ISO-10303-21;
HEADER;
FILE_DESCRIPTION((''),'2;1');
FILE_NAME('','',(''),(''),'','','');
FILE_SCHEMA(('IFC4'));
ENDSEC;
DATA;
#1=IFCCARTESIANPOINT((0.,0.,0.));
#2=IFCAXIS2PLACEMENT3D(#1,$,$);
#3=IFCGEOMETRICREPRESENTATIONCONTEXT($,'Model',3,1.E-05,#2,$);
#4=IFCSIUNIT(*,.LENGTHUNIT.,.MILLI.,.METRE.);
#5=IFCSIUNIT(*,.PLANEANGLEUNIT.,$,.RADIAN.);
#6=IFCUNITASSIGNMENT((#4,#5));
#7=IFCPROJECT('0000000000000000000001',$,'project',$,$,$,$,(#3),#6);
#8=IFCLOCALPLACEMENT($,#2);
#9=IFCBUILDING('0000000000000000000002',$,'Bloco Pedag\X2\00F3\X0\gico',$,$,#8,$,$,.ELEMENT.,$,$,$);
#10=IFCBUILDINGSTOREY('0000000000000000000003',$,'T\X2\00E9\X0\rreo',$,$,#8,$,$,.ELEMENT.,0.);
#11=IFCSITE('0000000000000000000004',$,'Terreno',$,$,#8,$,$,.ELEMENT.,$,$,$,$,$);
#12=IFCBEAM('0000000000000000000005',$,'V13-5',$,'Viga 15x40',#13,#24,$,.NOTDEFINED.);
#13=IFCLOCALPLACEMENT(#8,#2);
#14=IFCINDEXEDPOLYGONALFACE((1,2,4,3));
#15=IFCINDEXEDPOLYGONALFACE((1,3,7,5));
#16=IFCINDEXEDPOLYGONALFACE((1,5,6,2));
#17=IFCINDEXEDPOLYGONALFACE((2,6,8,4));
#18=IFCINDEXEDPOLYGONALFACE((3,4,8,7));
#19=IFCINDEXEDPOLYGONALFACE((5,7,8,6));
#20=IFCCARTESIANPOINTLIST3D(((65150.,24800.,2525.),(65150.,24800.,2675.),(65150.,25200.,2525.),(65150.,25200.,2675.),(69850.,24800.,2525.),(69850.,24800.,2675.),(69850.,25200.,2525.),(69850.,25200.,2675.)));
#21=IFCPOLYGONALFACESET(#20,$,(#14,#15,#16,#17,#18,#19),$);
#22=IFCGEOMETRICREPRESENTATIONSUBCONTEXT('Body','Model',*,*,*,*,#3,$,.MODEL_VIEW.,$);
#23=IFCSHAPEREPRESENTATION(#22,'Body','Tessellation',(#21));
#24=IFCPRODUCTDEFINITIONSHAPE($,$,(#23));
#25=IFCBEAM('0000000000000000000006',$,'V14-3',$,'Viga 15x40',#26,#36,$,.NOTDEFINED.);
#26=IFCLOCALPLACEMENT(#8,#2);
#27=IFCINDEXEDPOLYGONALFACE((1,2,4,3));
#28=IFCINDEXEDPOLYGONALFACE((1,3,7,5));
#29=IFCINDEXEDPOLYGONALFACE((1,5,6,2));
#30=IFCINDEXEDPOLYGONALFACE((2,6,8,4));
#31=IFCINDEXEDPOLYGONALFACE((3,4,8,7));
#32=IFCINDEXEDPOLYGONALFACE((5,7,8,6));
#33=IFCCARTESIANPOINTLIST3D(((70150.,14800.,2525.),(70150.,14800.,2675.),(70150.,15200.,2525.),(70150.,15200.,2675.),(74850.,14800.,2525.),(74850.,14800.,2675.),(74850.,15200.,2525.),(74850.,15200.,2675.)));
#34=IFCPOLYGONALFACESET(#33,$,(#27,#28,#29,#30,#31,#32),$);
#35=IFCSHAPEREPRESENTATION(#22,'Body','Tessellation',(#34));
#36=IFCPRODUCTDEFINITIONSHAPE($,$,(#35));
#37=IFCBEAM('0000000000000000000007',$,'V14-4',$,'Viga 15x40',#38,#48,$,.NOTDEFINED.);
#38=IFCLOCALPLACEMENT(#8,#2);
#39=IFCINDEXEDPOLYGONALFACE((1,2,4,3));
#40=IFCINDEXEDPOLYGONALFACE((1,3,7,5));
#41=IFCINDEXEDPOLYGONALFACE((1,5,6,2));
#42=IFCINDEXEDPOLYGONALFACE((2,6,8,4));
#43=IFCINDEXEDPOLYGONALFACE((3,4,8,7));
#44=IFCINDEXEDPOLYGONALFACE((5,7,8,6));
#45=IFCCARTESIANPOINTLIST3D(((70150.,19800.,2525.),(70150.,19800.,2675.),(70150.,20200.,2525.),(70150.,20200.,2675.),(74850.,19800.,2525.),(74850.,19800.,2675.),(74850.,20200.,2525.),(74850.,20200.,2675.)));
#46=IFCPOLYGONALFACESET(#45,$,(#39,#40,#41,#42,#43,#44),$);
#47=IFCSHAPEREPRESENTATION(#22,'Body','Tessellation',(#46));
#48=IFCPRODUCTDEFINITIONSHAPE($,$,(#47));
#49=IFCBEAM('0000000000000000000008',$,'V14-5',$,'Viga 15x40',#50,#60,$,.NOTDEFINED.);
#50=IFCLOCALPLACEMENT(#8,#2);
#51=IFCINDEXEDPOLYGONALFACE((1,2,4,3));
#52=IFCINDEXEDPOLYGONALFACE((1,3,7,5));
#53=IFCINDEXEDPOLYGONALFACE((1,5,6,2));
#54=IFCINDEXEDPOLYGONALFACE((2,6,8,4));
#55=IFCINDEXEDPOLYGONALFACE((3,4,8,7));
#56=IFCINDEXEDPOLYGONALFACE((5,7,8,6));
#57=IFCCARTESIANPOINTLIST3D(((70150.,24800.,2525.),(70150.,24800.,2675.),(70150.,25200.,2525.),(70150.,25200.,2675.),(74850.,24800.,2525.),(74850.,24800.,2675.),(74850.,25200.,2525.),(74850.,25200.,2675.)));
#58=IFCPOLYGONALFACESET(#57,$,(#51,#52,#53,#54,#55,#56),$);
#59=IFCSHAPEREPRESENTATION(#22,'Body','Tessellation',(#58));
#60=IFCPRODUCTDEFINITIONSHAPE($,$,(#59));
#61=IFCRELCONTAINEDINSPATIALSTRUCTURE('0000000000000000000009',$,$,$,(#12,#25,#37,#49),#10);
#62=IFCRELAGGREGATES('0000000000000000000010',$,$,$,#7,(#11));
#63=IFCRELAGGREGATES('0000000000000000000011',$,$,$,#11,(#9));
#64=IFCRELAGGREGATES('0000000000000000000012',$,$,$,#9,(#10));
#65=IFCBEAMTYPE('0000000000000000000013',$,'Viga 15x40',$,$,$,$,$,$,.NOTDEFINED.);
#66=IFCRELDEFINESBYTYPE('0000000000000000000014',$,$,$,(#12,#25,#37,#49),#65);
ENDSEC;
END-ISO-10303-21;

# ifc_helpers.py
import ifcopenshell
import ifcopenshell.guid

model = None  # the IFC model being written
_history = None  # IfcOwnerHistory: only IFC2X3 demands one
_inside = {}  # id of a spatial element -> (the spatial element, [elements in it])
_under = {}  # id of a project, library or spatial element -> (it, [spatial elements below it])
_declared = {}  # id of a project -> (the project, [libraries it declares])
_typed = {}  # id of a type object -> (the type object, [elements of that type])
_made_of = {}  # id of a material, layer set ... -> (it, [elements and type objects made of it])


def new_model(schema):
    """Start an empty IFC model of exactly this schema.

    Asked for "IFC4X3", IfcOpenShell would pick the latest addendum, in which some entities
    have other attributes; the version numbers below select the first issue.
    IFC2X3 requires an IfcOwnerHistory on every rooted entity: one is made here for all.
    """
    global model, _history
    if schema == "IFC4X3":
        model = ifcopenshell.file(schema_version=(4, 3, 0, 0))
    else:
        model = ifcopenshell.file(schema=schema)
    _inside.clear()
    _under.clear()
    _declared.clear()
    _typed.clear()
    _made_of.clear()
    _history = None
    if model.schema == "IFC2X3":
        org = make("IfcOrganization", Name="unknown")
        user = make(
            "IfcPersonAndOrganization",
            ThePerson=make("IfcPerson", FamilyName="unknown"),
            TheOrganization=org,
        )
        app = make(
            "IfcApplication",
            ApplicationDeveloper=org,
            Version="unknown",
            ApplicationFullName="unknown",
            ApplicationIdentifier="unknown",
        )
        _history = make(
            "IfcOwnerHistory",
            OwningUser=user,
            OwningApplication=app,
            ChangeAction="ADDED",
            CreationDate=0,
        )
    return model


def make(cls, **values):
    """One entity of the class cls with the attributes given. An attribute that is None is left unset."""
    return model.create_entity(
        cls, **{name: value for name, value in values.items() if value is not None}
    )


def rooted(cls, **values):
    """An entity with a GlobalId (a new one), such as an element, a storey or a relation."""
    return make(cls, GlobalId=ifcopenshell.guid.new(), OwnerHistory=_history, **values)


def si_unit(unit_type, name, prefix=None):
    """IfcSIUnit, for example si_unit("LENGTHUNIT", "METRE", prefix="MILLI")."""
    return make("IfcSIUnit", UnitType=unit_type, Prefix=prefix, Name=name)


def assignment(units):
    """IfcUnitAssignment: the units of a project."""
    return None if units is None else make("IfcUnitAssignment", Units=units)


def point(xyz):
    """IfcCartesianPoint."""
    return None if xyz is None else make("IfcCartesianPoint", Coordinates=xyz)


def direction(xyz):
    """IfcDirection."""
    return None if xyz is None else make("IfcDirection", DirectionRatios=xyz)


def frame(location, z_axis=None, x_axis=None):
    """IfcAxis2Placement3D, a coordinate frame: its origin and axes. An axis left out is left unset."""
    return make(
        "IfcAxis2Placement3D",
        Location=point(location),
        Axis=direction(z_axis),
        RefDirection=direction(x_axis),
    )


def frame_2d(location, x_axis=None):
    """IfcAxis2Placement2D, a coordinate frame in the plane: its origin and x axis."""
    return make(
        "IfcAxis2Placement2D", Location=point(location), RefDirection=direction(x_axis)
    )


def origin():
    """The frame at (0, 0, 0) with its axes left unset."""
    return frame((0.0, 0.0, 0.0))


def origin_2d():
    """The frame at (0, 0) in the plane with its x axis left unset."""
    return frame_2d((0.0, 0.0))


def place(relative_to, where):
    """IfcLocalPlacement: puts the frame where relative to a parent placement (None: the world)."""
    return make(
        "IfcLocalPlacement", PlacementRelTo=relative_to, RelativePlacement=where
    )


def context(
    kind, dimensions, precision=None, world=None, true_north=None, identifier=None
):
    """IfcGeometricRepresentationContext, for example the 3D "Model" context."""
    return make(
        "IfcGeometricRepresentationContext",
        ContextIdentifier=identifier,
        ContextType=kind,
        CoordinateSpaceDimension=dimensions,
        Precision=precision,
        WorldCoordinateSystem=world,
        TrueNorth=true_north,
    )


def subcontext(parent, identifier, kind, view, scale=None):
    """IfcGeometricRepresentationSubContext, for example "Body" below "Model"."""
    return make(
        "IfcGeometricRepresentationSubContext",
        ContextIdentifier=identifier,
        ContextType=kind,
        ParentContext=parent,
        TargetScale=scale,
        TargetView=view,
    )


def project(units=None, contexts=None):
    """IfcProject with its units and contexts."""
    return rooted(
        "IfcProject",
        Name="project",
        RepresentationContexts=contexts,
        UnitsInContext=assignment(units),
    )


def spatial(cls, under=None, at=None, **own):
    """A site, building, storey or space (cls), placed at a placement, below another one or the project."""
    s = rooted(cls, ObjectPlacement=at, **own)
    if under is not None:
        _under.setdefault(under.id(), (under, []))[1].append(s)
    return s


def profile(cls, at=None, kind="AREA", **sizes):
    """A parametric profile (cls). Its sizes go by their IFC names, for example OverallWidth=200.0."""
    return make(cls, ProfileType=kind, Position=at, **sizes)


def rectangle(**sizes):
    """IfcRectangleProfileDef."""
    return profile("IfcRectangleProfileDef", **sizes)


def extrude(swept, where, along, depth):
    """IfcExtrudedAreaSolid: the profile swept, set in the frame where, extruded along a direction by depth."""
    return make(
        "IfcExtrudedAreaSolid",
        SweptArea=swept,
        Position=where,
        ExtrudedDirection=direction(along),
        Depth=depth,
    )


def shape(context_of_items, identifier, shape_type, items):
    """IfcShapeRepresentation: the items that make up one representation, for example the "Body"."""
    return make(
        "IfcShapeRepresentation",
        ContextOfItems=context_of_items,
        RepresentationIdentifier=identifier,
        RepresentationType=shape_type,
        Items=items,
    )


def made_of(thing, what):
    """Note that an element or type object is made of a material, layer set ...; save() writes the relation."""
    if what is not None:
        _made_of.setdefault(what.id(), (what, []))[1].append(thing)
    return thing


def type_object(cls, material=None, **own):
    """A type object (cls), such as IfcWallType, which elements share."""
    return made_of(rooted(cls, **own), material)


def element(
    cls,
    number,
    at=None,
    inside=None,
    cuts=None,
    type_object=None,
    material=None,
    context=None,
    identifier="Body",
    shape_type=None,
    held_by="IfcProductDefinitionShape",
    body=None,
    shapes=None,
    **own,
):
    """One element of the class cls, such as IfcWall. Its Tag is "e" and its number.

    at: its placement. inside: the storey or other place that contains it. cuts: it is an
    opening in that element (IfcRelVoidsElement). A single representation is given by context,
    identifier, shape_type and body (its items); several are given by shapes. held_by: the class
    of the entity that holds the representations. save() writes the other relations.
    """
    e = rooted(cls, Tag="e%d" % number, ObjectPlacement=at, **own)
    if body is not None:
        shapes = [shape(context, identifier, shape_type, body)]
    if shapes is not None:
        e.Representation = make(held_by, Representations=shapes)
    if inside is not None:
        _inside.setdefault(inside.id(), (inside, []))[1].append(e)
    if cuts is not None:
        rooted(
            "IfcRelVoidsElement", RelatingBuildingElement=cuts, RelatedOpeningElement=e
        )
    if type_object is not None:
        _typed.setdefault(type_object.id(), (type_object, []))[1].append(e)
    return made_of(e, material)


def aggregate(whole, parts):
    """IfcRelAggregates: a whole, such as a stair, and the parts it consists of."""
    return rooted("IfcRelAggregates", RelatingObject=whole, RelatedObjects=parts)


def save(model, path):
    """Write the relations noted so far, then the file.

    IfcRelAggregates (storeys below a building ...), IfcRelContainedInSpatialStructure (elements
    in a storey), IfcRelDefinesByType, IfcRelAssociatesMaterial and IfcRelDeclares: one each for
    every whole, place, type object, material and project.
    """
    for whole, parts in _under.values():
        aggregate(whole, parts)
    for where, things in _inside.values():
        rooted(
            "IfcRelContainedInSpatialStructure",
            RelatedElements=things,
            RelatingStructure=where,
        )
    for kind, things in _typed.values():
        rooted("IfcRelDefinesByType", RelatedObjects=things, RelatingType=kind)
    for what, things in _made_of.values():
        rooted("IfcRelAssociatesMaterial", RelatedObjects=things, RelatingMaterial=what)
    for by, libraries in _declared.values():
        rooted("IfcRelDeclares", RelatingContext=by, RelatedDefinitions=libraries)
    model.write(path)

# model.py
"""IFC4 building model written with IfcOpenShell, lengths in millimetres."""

from ifc_helpers import new_model, si_unit, frame, origin, origin_2d, place, context, subcontext, project, spatial, rectangle, extrude, type_object, element, save


model = new_model("IFC4")

# Units and contexts
model_context = context("Model", 3, precision=1e-05, world=origin())
body_context = subcontext(model_context, "Body", "Model", "MODEL_VIEW")
ifc_project = project(units=[si_unit("LENGTHUNIT", "METRE", prefix="MILLI"), si_unit("PLANEANGLEUNIT", "RADIAN")], contexts=[model_context])

# Site, building, storey
placement = place(None, origin())
site = spatial("IfcSite", under=ifc_project, at=placement, Name="Terreno", CompositionType="ELEMENT")
building = spatial("IfcBuilding", under=site, at=placement, Name="Bloco Pedagógico", CompositionType="ELEMENT")
storey = spatial("IfcBuildingStorey", under=building, at=placement, Name="Térreo", CompositionType="ELEMENT", Elevation=0.0)

# Beams
beam_type = type_object("IfcBeamType", Name="Viga 15x40", PredefinedType="NOTDEFINED")
for number, where, z_axis, x_axis, name in (
    (1, (65150.0, 25000.0, 2600.0), (1.0, 0.0, 0.0), (0.0, 1.0, 0.0), "V13-5"),
    (2, (70150.0, 15000.0, 2600.0), (1.0, 0.0, 0.0), (0.0, 1.0, 0.0), "V14-3"),
    (3, (70150.0, 20000.0, 2600.0), (1.0, 0.0, 0.0), (0.0, 1.0, 0.0), "V14-4"),
    (4, (70150.0, 25000.0, 2600.0), (1.0, 0.0, 0.0), (0.0, 1.0, 0.0), "V14-5"),
):
    element("IfcBeam", number, at=place(None, frame(where, z_axis=z_axis, x_axis=x_axis)), inside=storey, type_object=beam_type, Name=name, ObjectType="Viga 15x40", PredefinedType="NOTDEFINED", context=body_context, shape_type="SweptSolid", body=[
        extrude(rectangle(XDim=400.0, YDim=150.0, at=origin_2d()), None, (0.0, 0.0, 1.0), 4700.0),
    ])

save(model, "model.ifc")
